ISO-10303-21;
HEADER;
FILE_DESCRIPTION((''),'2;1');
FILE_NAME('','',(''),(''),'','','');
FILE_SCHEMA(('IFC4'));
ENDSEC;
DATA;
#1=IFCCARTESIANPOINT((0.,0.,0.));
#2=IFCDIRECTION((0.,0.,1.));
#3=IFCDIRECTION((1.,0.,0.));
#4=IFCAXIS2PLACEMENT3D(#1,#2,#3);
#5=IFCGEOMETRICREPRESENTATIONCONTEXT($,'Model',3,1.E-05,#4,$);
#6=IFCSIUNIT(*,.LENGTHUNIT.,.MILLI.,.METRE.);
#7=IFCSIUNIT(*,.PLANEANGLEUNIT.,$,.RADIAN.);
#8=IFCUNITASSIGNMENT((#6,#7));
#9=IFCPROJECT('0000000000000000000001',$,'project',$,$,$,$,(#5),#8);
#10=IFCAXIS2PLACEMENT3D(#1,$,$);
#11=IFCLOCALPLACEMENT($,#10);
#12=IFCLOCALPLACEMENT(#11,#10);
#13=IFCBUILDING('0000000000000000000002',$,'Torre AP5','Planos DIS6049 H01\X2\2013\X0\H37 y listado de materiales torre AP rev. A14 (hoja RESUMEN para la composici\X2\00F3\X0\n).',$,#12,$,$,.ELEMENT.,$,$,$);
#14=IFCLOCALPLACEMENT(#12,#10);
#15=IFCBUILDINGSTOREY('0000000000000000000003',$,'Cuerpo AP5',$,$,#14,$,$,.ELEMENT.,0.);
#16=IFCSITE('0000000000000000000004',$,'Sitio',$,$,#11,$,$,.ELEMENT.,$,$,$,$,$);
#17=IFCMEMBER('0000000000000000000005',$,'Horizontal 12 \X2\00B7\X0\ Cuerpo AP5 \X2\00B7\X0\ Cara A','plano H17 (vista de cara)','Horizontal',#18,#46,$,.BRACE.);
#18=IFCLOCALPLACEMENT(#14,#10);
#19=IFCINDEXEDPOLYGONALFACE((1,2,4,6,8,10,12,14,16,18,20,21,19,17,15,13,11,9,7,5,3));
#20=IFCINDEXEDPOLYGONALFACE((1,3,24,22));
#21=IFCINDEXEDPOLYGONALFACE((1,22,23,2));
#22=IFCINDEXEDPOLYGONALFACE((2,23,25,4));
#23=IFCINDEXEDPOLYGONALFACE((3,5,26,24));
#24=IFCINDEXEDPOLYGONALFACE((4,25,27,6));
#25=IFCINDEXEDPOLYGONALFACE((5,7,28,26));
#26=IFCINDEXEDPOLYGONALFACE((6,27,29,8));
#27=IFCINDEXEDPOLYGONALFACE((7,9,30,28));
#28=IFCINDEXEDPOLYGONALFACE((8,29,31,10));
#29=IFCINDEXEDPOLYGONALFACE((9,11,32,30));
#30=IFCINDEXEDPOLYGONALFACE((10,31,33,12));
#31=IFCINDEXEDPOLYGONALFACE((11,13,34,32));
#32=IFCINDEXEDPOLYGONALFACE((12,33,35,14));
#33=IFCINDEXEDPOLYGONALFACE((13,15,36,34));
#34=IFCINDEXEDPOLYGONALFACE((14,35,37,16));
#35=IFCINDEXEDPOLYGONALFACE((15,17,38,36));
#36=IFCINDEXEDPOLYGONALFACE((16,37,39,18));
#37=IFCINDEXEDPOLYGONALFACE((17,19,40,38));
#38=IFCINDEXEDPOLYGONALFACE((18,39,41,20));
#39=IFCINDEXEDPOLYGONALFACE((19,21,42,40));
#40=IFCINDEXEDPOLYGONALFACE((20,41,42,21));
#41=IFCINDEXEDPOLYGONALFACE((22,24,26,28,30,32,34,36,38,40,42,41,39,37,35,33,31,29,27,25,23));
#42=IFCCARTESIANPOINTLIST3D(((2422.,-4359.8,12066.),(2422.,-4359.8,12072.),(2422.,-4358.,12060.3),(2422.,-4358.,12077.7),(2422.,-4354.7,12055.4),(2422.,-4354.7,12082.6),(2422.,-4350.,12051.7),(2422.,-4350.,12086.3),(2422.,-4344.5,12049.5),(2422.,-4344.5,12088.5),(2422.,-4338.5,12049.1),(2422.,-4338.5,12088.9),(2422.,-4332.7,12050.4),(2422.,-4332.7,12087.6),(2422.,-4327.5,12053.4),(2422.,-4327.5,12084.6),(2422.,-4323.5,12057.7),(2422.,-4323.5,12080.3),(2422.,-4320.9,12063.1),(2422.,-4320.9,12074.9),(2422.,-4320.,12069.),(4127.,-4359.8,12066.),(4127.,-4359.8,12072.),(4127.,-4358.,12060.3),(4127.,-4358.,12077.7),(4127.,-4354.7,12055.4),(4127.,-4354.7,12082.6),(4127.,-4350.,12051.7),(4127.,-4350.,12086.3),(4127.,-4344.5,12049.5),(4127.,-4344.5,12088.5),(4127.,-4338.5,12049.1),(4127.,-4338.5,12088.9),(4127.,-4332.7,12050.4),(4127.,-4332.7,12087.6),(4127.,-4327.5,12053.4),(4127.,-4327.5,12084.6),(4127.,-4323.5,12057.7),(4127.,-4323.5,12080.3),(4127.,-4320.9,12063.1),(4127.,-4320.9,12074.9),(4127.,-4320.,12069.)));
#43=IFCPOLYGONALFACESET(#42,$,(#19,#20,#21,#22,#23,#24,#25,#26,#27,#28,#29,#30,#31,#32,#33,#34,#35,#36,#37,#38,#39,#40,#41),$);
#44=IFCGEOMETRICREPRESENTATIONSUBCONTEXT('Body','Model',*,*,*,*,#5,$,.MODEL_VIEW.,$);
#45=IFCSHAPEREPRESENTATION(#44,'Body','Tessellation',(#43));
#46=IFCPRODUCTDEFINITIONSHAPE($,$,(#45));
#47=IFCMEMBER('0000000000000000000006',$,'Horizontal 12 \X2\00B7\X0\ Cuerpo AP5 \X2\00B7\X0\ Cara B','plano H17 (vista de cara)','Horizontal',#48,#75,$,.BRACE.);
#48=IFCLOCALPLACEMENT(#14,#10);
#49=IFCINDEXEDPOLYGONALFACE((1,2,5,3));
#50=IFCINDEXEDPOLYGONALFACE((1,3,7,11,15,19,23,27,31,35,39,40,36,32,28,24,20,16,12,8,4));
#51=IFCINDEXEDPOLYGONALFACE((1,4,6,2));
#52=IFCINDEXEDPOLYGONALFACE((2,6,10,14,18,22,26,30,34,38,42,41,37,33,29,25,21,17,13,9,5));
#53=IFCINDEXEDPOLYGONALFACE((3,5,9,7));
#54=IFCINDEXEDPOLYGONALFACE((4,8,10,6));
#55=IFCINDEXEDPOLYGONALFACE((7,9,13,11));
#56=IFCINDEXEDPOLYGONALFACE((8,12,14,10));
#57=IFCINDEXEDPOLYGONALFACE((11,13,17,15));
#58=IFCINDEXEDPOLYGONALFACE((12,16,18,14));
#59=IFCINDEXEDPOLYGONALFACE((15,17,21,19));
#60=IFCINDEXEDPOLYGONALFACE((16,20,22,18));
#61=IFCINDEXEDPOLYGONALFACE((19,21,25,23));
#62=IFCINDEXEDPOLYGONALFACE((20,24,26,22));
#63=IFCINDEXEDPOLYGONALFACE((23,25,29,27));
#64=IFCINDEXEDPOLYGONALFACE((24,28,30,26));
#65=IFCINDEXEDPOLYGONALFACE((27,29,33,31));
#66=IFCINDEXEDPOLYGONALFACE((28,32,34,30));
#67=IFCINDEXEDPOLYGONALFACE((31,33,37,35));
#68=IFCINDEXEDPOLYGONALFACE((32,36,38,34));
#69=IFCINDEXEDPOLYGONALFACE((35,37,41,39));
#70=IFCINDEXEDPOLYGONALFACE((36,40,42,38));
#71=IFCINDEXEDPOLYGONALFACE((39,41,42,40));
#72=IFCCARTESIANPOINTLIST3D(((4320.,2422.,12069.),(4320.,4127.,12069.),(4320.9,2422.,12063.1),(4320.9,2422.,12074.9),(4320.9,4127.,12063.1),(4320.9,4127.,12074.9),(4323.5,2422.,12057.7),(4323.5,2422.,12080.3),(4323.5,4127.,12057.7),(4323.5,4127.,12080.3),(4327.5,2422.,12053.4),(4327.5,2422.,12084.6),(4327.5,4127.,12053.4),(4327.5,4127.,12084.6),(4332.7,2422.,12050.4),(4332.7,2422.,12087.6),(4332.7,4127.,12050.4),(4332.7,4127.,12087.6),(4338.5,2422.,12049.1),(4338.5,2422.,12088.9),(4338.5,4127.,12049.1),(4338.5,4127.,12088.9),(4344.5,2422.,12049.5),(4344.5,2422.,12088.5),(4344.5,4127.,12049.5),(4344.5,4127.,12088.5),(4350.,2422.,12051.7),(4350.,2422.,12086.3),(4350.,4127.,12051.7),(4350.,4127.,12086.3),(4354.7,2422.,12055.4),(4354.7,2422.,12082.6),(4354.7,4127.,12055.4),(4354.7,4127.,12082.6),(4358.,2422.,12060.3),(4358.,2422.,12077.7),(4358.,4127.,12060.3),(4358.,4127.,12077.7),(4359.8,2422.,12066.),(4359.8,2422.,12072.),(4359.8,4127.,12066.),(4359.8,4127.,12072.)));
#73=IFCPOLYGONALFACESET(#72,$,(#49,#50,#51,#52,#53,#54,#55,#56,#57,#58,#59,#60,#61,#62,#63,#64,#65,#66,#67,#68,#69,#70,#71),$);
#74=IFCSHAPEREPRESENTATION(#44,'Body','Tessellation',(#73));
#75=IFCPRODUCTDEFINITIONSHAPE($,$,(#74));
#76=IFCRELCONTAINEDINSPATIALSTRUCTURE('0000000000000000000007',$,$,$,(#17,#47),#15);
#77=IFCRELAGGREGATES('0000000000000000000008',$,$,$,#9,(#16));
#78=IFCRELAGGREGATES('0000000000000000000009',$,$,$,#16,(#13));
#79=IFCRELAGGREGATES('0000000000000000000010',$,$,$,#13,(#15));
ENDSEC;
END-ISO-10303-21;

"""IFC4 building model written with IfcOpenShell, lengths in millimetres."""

from ifc_helpers import new_model, si_unit, frame, origin, origin_with_axes, place, context, subcontext, project, spatial, circle, extrude, element, save


model = new_model("IFC4")

# Units and contexts
model_context = context("Model", 3, precision=1e-05, world=origin_with_axes())
body_context = subcontext(model_context, "Body", "Model", "MODEL_VIEW")
ifc_project = project(units=[si_unit("LENGTHUNIT", "METRE", prefix="MILLI"), si_unit("PLANEANGLEUNIT", "RADIAN")], contexts=[model_context])

# Site, building, storey
site_placement = place(None, origin())
site = spatial("IfcSite", under=ifc_project, at=site_placement, Name="Sitio", CompositionType="ELEMENT")
building_placement = place(site_placement, origin())
building = spatial("IfcBuilding", under=site, at=building_placement, Name="Torre AP5", Description="Planos DIS6049 H01–H37 y listado de materiales torre AP rev. A14 (hoja RESUMEN para la composición).", CompositionType="ELEMENT")
storey_placement = place(building_placement, origin())
storey = spatial("IfcBuildingStorey", under=building, at=storey_placement, Name="Cuerpo AP5", CompositionType="ELEMENT", Elevation=0.0)

# Members
for number, where, z_axis, x_axis, name in (
    (1, (4127.0, -4340.0, 12069.0), (-1.0, 0.0, 0.0), (0.0, 1.0, 0.0), "Horizontal 12 · Cuerpo AP5 · Cara A"),
    (2, (4340.0, 4127.0, 12069.0), (0.0, -1.0, 0.0), (-1.0, 0.0, 0.0), "Horizontal 12 · Cuerpo AP5 · Cara B"),
):
    element("IfcMember", number, at=place(storey_placement, frame(where, z_axis=z_axis, x_axis=x_axis)), inside=storey, Name=name, Description="plano H17 (vista de cara)", ObjectType="Horizontal", PredefinedType="BRACE", context=body_context, shape_type="SweptSolid", body=[
        extrude(circle(Radius=20.0), None, (0.0, 0.0, 1.0), 1705.0),
    ])

save(model, "model.ifc")
